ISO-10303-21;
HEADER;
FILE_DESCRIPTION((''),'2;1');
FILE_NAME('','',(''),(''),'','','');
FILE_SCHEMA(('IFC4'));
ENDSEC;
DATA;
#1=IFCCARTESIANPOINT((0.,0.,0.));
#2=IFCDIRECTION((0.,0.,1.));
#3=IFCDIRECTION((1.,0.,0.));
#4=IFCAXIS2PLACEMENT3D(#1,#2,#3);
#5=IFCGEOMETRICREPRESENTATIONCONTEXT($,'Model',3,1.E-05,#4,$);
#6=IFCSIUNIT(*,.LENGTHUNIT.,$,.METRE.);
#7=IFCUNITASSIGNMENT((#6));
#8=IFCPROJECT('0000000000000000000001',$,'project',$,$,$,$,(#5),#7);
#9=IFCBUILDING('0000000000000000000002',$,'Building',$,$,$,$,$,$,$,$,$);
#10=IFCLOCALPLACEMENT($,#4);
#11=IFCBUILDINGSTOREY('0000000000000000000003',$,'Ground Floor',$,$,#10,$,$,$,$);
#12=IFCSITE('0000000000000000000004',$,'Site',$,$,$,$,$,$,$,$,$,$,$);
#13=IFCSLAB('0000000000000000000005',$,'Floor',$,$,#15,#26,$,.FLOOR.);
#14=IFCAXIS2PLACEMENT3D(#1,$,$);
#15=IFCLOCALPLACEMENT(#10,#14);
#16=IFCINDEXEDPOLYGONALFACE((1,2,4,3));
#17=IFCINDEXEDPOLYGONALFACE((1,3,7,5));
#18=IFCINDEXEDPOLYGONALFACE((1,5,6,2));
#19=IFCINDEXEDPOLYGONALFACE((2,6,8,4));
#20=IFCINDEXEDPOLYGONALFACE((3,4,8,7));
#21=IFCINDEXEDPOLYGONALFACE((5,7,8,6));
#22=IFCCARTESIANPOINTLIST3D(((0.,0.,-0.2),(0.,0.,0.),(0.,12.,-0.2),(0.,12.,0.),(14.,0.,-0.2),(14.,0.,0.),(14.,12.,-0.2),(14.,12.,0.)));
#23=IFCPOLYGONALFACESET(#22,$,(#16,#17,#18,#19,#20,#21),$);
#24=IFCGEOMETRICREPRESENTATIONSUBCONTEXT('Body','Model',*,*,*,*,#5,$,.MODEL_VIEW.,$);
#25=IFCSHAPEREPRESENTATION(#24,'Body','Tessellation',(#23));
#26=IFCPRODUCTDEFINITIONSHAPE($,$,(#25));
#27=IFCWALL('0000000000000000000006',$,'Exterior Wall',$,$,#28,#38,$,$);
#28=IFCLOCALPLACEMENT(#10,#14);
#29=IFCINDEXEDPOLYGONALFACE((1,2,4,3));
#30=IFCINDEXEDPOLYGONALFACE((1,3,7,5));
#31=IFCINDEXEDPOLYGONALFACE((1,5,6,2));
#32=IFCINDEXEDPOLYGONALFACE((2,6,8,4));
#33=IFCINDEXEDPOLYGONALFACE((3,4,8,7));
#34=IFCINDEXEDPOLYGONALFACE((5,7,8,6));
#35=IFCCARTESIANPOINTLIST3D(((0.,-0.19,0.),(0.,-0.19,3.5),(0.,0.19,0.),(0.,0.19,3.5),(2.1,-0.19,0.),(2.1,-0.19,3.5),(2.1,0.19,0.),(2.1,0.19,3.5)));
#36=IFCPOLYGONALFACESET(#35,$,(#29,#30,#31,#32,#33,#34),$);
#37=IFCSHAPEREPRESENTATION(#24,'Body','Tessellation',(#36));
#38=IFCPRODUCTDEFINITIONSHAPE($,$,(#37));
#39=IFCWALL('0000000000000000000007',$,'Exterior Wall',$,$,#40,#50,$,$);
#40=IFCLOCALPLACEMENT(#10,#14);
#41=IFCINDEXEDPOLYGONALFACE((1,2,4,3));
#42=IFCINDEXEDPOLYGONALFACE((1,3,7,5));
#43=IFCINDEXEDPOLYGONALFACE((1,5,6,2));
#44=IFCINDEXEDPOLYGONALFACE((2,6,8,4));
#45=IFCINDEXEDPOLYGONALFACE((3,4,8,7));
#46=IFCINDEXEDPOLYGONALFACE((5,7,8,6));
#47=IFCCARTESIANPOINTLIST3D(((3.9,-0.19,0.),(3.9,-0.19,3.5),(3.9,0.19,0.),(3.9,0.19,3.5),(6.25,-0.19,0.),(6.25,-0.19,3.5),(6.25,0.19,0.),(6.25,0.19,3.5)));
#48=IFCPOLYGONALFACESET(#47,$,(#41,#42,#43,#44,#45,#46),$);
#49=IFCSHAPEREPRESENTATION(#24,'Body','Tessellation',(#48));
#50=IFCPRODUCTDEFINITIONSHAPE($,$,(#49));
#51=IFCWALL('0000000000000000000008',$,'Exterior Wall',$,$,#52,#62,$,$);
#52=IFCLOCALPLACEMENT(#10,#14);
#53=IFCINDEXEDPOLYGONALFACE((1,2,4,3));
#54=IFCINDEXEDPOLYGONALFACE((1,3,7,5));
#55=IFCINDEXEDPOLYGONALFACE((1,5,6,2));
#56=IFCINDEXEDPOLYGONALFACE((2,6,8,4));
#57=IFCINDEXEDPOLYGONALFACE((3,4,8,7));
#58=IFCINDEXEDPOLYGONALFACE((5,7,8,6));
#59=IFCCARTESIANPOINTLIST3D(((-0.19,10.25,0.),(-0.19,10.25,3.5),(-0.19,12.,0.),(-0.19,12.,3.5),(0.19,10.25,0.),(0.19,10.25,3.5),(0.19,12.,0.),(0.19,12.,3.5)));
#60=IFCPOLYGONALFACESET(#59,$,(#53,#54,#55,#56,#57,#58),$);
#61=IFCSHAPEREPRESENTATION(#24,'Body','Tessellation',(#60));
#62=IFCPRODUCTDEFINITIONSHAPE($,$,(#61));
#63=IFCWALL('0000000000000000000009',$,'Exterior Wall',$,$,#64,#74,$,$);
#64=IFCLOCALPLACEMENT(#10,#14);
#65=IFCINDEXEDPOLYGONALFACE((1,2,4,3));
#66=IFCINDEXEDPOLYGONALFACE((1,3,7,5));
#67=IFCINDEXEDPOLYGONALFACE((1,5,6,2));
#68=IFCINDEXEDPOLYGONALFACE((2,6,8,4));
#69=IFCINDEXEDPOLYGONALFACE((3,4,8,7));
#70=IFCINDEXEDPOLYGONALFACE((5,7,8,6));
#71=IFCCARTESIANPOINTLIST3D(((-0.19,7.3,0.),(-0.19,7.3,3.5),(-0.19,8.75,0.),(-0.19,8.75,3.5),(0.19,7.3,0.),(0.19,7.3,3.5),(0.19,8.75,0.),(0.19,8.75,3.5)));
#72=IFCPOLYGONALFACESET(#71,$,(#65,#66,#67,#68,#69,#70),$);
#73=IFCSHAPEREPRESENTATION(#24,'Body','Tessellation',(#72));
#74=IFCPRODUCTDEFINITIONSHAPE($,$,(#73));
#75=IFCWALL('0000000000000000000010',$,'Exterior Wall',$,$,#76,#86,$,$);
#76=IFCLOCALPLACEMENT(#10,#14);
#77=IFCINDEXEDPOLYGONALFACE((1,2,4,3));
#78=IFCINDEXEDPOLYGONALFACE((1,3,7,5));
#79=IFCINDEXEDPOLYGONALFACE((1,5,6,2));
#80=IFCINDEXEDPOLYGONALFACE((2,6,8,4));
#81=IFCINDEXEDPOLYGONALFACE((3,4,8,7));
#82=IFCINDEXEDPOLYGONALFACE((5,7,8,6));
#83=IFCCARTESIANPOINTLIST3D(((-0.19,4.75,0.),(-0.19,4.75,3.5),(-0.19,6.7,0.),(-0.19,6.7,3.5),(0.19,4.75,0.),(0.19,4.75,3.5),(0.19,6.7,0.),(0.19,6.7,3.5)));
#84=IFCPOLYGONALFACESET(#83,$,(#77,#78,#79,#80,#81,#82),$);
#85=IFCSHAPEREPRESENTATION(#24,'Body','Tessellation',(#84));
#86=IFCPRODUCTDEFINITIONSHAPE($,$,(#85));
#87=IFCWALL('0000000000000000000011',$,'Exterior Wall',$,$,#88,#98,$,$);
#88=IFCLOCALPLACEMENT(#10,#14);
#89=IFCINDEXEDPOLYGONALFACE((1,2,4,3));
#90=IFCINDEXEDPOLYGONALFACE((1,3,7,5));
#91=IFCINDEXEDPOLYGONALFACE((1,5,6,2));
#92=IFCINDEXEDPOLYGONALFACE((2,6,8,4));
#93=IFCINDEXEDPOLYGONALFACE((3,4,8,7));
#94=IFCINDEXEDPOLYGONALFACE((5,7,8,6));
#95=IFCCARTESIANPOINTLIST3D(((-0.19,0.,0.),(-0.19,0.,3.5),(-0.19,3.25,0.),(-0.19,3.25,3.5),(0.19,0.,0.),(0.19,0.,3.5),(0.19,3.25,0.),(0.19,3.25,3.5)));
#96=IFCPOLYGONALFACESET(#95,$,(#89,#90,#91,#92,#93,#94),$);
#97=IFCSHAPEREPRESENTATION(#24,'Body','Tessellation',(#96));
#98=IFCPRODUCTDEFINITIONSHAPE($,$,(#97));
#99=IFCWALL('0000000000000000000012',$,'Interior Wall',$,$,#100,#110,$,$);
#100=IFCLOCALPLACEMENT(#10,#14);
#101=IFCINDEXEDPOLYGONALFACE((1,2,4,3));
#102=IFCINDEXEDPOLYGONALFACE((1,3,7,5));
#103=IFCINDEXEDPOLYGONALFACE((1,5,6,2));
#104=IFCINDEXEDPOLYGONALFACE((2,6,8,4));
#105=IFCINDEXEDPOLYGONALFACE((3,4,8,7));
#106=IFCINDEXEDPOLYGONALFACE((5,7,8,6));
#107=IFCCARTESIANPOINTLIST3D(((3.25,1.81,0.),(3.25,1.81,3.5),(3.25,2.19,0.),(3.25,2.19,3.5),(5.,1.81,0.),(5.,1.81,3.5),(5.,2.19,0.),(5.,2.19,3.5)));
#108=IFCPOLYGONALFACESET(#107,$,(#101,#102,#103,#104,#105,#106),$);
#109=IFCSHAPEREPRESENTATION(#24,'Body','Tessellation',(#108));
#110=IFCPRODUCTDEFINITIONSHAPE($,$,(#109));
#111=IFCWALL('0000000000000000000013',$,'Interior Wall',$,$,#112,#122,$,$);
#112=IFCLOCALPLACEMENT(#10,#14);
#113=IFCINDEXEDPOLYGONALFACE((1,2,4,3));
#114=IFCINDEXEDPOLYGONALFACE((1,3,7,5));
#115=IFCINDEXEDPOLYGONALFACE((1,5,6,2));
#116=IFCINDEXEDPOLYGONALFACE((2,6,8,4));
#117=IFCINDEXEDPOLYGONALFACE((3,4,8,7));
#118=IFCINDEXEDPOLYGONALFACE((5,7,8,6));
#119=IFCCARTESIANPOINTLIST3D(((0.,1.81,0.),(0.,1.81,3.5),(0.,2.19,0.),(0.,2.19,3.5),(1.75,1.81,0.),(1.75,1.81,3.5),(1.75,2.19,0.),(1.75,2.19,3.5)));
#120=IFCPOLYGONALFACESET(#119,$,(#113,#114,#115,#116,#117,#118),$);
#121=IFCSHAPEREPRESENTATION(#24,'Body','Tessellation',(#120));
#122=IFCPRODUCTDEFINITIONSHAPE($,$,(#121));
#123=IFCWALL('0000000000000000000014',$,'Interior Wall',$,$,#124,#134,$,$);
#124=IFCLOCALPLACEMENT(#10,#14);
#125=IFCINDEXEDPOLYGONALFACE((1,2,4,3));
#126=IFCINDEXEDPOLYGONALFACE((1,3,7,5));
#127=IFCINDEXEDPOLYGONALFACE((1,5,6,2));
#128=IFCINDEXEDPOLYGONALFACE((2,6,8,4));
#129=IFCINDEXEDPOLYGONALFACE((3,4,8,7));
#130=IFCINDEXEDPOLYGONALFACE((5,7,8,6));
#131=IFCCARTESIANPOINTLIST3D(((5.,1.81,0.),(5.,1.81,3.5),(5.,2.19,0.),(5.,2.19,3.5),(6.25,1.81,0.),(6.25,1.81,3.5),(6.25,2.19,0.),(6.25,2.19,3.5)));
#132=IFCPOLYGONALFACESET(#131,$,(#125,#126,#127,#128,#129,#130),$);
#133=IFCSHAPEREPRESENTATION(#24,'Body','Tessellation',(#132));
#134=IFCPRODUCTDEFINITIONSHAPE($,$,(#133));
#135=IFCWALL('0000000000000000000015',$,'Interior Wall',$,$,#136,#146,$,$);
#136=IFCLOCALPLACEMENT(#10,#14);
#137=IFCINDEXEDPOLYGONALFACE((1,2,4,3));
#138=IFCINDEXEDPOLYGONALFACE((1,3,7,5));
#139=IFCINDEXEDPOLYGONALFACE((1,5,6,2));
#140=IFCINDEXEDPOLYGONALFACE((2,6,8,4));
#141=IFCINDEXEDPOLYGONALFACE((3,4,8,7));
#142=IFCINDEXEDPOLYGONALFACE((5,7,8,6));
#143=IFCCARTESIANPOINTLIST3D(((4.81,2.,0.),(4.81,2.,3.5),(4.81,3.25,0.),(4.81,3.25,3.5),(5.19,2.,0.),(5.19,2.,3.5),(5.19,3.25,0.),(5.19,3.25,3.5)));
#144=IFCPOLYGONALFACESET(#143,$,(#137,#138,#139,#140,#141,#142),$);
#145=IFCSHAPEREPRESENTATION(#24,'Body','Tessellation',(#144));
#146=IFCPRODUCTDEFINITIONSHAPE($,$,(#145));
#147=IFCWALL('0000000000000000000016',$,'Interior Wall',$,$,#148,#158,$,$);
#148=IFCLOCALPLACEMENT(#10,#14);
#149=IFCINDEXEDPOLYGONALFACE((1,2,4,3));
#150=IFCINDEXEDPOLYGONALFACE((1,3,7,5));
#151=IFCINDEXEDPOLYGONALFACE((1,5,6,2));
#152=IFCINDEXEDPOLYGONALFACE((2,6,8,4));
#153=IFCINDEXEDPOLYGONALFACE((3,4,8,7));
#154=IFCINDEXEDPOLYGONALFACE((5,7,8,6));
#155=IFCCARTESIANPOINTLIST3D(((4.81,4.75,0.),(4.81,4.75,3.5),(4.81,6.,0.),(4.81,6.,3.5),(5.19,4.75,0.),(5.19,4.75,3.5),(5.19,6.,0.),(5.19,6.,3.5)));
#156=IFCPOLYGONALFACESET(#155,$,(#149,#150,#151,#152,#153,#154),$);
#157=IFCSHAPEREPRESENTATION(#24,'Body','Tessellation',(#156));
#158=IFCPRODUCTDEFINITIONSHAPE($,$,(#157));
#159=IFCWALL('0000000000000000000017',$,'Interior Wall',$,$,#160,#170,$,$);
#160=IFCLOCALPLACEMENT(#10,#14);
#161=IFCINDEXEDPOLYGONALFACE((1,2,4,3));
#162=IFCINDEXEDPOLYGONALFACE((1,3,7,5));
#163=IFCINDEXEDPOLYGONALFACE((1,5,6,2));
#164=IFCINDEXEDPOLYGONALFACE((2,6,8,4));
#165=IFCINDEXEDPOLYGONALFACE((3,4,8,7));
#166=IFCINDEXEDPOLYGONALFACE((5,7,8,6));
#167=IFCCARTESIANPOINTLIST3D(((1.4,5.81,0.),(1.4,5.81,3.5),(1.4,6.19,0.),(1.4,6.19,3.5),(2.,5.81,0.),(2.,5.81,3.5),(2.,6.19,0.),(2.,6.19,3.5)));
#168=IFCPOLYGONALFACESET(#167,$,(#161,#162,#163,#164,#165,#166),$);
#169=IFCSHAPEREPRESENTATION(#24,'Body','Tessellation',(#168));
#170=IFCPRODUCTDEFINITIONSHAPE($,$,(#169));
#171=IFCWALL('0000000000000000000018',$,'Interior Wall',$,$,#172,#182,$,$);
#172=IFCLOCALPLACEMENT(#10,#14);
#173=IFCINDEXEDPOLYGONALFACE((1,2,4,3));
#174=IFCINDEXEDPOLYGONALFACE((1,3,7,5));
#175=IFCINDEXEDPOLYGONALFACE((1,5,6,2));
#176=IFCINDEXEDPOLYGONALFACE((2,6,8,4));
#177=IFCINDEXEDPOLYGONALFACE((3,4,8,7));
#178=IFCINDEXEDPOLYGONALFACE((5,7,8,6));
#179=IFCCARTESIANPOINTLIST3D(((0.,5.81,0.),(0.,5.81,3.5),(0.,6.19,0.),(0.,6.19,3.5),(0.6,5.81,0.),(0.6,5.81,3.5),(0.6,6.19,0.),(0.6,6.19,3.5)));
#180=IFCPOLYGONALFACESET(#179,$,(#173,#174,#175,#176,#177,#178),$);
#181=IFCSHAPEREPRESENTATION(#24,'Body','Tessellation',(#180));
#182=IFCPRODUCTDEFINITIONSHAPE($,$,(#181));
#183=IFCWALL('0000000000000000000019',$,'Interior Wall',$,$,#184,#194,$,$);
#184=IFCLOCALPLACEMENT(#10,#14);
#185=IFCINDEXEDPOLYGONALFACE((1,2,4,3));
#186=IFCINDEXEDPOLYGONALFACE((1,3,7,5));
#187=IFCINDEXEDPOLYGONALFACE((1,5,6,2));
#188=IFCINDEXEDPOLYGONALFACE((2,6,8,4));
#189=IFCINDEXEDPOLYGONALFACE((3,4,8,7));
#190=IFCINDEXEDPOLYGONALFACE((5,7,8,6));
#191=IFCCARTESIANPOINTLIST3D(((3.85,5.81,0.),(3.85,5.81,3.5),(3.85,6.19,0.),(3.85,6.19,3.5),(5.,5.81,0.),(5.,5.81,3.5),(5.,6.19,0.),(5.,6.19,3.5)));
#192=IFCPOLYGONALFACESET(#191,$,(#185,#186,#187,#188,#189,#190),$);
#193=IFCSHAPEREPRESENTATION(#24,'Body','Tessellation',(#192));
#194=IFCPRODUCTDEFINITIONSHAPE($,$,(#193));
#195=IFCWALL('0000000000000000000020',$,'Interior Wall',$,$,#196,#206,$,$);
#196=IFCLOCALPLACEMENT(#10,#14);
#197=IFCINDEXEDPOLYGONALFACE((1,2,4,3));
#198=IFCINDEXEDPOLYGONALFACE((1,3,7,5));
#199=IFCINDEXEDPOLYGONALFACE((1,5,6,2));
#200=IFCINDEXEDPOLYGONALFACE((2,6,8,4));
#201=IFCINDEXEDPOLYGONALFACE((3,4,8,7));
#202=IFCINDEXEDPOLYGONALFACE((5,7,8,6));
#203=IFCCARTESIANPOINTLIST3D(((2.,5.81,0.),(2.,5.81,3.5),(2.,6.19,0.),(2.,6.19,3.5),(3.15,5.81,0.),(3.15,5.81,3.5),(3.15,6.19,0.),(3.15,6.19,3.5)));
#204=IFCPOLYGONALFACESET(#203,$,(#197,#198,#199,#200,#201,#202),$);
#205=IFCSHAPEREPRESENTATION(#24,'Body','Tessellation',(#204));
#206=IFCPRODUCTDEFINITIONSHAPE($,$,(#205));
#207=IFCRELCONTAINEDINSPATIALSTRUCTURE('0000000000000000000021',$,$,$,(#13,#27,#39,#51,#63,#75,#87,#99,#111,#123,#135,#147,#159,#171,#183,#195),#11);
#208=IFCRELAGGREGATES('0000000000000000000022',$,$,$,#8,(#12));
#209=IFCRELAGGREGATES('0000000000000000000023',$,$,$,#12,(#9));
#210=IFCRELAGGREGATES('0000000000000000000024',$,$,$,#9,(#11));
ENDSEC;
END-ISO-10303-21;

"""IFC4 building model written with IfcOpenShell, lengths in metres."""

from ifc_helpers import new_model, si_unit, frame, origin_with_axes, place, context, subcontext, project, spatial, indexed_curve, outline, extrude, element, save


model = new_model("IFC4")

# Units and contexts
model_context = context("Model", 3, precision=1e-05, world=origin_with_axes())
body_context = subcontext(model_context, "Body", "Model", "MODEL_VIEW")
ifc_project = project(units=[si_unit("LENGTHUNIT", "METRE")], contexts=[model_context])

# Site, building, storey
site = spatial("IfcSite", under=ifc_project, Name="Site")
building = spatial("IfcBuilding", under=site, Name="Building")
storey_placement = place(None, origin_with_axes())
storey = spatial("IfcBuildingStorey", under=building, at=storey_placement, Name="Ground Floor")

# Slab
slab_placement = place(storey_placement, frame((0.0, 0.0, -0.2), z_axis=(0.0, 0.0, 1.0), x_axis=(1.0, 0.0, 0.0)))
element("IfcSlab", 1, at=slab_placement, inside=storey, Name="Floor", PredefinedType="FLOOR", context=body_context, shape_type="SweptSolid", body=[
    extrude(outline(indexed_curve([(0.0, 0.0), (14.0, 0.0), (14.0, 12.0), (0.0, 12.0)])), None, (0.0, 0.0, 1.0), 0.2),
])

# Walls
wall_1_placement = place(storey_placement, origin_with_axes())
element("IfcWall", 2, at=wall_1_placement, inside=storey, Name="Exterior Wall", context=body_context, shape_type="SweptSolid", body=[
    extrude(outline(indexed_curve([(0.0, 0.0), (0.0, 0.38), (2.1, 0.38), (2.1, 0.0), (0.0, 0.0)], self_intersect=False)), frame((0.0, -0.19, 0.0), z_axis=(0.0, 0.0, 1.0), x_axis=(1.0, 0.0, 0.0)), (0.0, 0.0, 1.0), 3.5),
])
wall_2_placement = place(storey_placement, frame((3.9, 0.0, 0.0), z_axis=(0.0, 0.0, 1.0), x_axis=(1.0, 0.0, 0.0)))
element("IfcWall", 3, at=wall_2_placement, inside=storey, Name="Exterior Wall", context=body_context, shape_type="SweptSolid", body=[
    extrude(outline(indexed_curve([(0.0, 0.0), (0.0, 0.38), (2.35, 0.38), (2.35, 0.0), (0.0, 0.0)], self_intersect=False)), frame((0.0, -0.19, 0.0), z_axis=(0.0, 0.0, 1.0), x_axis=(1.0, 0.0, 0.0)), (0.0, 0.0, 1.0), 3.5),
])
wall_3_placement = place(storey_placement, frame((0.0, 12.0, 0.0), z_axis=(0.0, 0.0, 1.0), x_axis=(0.0, -1.0, 0.0)))
element("IfcWall", 4, at=wall_3_placement, inside=storey, Name="Exterior Wall", context=body_context, shape_type="SweptSolid", body=[
    extrude(outline(indexed_curve([(0.0, 0.0), (0.0, 0.38), (1.75, 0.38), (1.75, 0.0), (0.0, 0.0)], self_intersect=False)), frame((0.0, -0.19, 0.0), z_axis=(0.0, 0.0, 1.0), x_axis=(1.0, 0.0, 0.0)), (0.0, 0.0, 1.0), 3.5),
])
wall_4_placement = place(storey_placement, frame((0.0, 8.75, 0.0), z_axis=(0.0, 0.0, 1.0), x_axis=(0.0, -1.0, 0.0)))
element("IfcWall", 5, at=wall_4_placement, inside=storey, Name="Exterior Wall", context=body_context, shape_type="SweptSolid", body=[
    extrude(outline(indexed_curve([(0.0, 0.0), (0.0, 0.38), (1.45, 0.38), (1.45, 0.0), (0.0, 0.0)], self_intersect=False)), frame((0.0, -0.19, 0.0), z_axis=(0.0, 0.0, 1.0), x_axis=(1.0, 0.0, 0.0)), (0.0, 0.0, 1.0), 3.5),
])
wall_5_placement = place(storey_placement, frame((0.0, 6.7, 0.0), z_axis=(0.0, 0.0, 1.0), x_axis=(0.0, -1.0, 0.0)))
element("IfcWall", 6, at=wall_5_placement, inside=storey, Name="Exterior Wall", context=body_context, shape_type="SweptSolid", body=[
    extrude(outline(indexed_curve([(0.0, 0.0), (0.0, 0.38), (1.95, 0.38), (1.95, 0.0), (0.0, 0.0)], self_intersect=False)), frame((0.0, -0.19, 0.0), z_axis=(0.0, 0.0, 1.0), x_axis=(1.0, 0.0, 0.0)), (0.0, 0.0, 1.0), 3.5),
])
wall_6_placement = place(storey_placement, frame((0.0, 3.25, 0.0), z_axis=(0.0, 0.0, 1.0), x_axis=(0.0, -1.0, 0.0)))
element("IfcWall", 7, at=wall_6_placement, inside=storey, Name="Exterior Wall", context=body_context, shape_type="SweptSolid", body=[
    extrude(outline(indexed_curve([(0.0, 0.0), (0.0, 0.38), (3.25, 0.38), (3.25, 0.0), (0.0, 0.0)], self_intersect=False)), frame((0.0, -0.19, 0.0), z_axis=(0.0, 0.0, 1.0), x_axis=(1.0, 0.0, 0.0)), (0.0, 0.0, 1.0), 3.5),
])
for number, where, z_axis, x_axis, name in (
    (8, (5.0, 2.0, 0.0), (0.0, 0.0, 1.0), (-1.0, 0.0, 0.0), "Interior Wall"),
    (9, (1.75, 2.0, 0.0), (0.0, 0.0, 1.0), (-1.0, 0.0, 0.0), "Interior Wall"),
):
    element("IfcWall", number, at=place(storey_placement, frame(where, z_axis=z_axis, x_axis=x_axis)), inside=storey, Name=name, context=body_context, shape_type="SweptSolid", body=[
        extrude(outline(indexed_curve([(0.0, 0.0), (0.0, 0.38), (1.75, 0.38), (1.75, 0.0), (0.0, 0.0)], self_intersect=False)), frame((0.0, -0.19, 0.0), z_axis=(0.0, 0.0, 1.0), x_axis=(1.0, 0.0, 0.0)), (0.0, 0.0, 1.0), 3.5),
    ])
for number, where, z_axis, x_axis, name in (
    (10, (6.25, 2.0, 0.0), (0.0, 0.0, 1.0), (-1.0, 0.0, 0.0), "Interior Wall"),
    (11, (5.0, 2.0, 0.0), (0.0, 0.0, 1.0), (0.0, 1.0, 0.0), "Interior Wall"),
    (12, (5.0, 4.75, 0.0), (0.0, 0.0, 1.0), (0.0, 1.0, 0.0), "Interior Wall"),
):
    element("IfcWall", number, at=place(storey_placement, frame(where, z_axis=z_axis, x_axis=x_axis)), inside=storey, Name=name, context=body_context, shape_type="SweptSolid", body=[
        extrude(outline(indexed_curve([(0.0, 0.0), (0.0, 0.38), (1.25, 0.38), (1.25, 0.0), (0.0, 0.0)], self_intersect=False)), frame((0.0, -0.19, 0.0), z_axis=(0.0, 0.0, 1.0), x_axis=(1.0, 0.0, 0.0)), (0.0, 0.0, 1.0), 3.5),
    ])
for number, where, z_axis, x_axis, name in (
    (13, (2.0, 6.0, 0.0), (0.0, 0.0, 1.0), (-1.0, 0.0, 0.0), "Interior Wall"),
    (14, (0.6, 6.0, 0.0), (0.0, 0.0, 1.0), (-1.0, 0.0, 0.0), "Interior Wall"),
):
    element("IfcWall", number, at=place(storey_placement, frame(where, z_axis=z_axis, x_axis=x_axis)), inside=storey, Name=name, context=body_context, shape_type="SweptSolid", body=[
        extrude(outline(indexed_curve([(0.0, 0.0), (0.0, 0.38), (0.6, 0.38), (0.6, 0.0), (0.0, 0.0)], self_intersect=False)), frame((0.0, -0.19, 0.0), z_axis=(0.0, 0.0, 1.0), x_axis=(1.0, 0.0, 0.0)), (0.0, 0.0, 1.0), 3.5),
    ])
for number, where, z_axis, x_axis, name in (
    (15, (5.0, 6.0, 0.0), (0.0, 0.0, 1.0), (-1.0, 0.0, 0.0), "Interior Wall"),
    (16, (3.15, 6.0, 0.0), (0.0, 0.0, 1.0), (-1.0, 0.0, 0.0), "Interior Wall"),
):
    element("IfcWall", number, at=place(storey_placement, frame(where, z_axis=z_axis, x_axis=x_axis)), inside=storey, Name=name, context=body_context, shape_type="SweptSolid", body=[
        extrude(outline(indexed_curve([(0.0, 0.0), (0.0, 0.38), (1.15, 0.38), (1.15, 0.0), (0.0, 0.0)], self_intersect=False)), frame((0.0, -0.19, 0.0), z_axis=(0.0, 0.0, 1.0), x_axis=(1.0, 0.0, 0.0)), (0.0, 0.0, 1.0), 3.5),
    ])

save(model, "model.ifc")
